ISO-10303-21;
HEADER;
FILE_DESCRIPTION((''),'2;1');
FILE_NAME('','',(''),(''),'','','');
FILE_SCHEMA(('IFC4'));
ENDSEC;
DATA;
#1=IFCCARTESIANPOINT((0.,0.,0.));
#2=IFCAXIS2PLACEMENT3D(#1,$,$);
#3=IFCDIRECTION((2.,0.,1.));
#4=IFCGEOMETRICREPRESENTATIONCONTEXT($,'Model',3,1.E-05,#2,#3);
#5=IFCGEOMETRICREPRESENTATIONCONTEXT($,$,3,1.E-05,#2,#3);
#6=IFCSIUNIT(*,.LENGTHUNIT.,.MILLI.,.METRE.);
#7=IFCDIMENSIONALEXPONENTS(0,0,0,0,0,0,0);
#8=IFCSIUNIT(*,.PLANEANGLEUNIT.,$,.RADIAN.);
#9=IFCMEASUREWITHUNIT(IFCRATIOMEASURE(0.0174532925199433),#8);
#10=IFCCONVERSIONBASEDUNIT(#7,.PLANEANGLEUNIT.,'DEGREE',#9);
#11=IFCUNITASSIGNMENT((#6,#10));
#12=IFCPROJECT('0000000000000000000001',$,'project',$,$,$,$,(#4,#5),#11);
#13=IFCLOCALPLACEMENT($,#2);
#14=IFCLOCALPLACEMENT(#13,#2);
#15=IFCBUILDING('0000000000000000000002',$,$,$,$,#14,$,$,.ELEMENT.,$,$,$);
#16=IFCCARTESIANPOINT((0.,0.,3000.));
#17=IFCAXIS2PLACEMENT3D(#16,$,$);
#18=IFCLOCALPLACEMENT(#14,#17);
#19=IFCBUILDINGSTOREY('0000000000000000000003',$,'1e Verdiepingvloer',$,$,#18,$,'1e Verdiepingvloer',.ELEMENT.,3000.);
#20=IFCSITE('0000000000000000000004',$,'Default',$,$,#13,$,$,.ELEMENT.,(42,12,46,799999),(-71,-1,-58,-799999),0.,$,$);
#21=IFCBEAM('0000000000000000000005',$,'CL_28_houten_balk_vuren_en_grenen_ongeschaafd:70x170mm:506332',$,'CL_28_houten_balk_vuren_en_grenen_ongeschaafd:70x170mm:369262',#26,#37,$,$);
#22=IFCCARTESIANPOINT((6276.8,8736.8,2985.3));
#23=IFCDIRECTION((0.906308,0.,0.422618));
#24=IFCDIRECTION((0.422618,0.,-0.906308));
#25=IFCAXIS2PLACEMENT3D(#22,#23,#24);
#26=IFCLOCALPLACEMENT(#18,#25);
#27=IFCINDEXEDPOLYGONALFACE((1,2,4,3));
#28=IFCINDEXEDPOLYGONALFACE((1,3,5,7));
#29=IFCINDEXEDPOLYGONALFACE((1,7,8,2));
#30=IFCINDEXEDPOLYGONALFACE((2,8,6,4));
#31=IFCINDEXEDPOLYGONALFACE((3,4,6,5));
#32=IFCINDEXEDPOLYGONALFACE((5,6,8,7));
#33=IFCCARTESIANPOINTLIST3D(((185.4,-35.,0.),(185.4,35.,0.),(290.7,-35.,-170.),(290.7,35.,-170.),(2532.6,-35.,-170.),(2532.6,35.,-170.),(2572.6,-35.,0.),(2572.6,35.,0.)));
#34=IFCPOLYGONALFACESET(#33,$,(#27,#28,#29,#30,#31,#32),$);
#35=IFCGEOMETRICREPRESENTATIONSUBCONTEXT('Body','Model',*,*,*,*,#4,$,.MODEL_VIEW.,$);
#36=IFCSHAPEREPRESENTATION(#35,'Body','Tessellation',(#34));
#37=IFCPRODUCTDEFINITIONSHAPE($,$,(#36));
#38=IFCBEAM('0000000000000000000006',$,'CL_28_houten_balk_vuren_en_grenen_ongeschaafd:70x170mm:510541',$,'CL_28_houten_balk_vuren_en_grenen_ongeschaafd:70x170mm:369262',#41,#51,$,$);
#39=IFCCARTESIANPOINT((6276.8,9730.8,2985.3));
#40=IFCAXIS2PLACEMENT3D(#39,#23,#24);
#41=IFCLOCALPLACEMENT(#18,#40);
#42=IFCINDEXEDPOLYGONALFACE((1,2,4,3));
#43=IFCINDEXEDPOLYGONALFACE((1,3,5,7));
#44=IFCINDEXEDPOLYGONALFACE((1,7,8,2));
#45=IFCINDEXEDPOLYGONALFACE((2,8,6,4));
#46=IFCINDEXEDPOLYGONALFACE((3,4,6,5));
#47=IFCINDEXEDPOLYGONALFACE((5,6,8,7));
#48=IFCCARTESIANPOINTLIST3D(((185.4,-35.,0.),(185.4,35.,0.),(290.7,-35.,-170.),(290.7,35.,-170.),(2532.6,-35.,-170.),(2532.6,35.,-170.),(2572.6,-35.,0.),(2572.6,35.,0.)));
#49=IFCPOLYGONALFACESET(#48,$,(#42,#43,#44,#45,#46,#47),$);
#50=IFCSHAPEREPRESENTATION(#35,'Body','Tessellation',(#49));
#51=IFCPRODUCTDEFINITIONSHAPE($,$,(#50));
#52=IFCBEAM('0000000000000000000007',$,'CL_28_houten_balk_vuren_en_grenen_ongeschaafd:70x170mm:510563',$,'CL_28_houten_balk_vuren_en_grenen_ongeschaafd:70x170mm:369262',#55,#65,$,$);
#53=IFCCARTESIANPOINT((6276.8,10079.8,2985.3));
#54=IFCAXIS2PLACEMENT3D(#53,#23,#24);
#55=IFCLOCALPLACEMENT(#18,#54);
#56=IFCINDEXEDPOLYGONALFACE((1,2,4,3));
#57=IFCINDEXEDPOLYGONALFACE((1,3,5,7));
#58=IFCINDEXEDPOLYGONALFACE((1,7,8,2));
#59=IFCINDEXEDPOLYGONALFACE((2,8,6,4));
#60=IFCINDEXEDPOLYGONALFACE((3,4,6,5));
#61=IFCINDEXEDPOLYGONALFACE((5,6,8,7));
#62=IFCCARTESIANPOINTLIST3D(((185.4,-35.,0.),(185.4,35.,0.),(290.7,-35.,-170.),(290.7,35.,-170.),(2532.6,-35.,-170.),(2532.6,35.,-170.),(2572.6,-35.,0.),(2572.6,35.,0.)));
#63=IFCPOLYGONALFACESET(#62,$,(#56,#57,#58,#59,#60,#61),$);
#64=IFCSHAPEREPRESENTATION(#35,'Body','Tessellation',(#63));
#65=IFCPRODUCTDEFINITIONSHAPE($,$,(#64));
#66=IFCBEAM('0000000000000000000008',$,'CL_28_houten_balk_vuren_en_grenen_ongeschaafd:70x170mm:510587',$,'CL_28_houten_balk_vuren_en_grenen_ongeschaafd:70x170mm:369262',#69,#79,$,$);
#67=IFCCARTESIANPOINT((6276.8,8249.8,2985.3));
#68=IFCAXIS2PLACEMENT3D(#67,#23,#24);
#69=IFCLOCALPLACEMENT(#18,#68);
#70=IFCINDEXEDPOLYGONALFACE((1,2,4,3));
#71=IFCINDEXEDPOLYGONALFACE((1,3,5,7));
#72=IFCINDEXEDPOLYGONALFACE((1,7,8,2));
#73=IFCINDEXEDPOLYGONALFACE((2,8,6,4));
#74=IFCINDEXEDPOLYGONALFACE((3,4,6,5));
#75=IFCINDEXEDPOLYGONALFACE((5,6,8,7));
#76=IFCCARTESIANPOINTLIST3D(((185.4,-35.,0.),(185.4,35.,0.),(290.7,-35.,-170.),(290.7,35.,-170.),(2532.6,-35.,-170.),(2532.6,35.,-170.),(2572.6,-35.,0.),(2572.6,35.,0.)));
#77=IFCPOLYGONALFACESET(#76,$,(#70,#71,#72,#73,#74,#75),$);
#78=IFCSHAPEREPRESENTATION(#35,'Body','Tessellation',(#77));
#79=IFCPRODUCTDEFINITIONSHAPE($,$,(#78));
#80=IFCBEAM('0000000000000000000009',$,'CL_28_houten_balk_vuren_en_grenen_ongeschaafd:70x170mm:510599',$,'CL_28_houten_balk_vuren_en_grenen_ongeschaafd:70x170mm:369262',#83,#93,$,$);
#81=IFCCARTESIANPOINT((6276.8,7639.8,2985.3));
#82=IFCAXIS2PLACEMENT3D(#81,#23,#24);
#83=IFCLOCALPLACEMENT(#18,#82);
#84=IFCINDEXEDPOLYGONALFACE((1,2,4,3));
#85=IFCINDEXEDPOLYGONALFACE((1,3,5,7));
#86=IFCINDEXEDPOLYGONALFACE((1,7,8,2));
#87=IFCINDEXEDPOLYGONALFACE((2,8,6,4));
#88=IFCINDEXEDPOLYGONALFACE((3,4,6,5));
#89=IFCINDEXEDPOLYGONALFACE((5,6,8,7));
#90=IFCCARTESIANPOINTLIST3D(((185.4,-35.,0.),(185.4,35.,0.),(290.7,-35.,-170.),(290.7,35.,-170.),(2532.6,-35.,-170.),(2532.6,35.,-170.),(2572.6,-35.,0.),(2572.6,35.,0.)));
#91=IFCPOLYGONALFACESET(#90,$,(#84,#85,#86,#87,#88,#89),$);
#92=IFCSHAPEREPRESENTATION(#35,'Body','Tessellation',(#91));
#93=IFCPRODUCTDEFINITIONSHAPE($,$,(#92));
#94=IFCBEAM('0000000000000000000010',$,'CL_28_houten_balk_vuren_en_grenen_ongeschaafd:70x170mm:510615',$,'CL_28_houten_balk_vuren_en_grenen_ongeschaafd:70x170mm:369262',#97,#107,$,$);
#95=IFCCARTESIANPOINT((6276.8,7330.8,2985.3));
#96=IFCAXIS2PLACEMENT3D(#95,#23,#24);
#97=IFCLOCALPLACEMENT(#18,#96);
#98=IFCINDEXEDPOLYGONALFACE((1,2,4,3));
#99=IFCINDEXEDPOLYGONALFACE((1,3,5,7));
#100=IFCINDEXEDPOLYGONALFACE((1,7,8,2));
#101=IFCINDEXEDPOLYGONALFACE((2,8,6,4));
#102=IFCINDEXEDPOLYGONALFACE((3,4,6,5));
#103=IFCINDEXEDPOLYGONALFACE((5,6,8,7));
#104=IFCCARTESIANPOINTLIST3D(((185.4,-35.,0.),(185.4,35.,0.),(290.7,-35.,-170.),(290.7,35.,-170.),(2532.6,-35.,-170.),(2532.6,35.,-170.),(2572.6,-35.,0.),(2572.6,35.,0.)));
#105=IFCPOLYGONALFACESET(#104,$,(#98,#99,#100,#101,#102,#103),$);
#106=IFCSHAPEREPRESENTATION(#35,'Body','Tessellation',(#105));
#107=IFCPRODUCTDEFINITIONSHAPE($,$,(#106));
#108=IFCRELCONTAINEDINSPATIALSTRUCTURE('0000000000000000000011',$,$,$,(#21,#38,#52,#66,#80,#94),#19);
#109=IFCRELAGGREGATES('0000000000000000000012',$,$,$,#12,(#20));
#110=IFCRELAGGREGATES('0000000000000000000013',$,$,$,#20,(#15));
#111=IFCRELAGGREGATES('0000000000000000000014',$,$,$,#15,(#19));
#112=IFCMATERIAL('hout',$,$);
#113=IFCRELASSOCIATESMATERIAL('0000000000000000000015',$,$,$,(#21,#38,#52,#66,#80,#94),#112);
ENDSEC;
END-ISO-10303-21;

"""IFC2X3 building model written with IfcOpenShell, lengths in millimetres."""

from ifc_helpers import new_model, entity, si_unit, converted_unit, direction, frame, frame_2d, origin, place, context, subcontext, project, spatial, rectangle, extrude, clip, halfspace, material, element, save


model = new_model("IFC2X3")

# Units and contexts
model_context = context("Model", 3, precision=1e-05, world=origin(), true_north=direction((2.0, 0.0, 1.0)))
context_of_model = context(None, 3, precision=1e-05, world=origin(), true_north=direction((2.0, 0.0, 1.0)))
body_context = subcontext(model_context, "Body", "Model", "MODEL_VIEW")
ifc_project = project(units=[si_unit("LENGTHUNIT", "METRE", prefix="MILLI"), converted_unit("PLANEANGLEUNIT", "DEGREE", entity("IfcRatioMeasure", 0.0174532925199433), si_unit("PLANEANGLEUNIT", "RADIAN"), dimensions=[0, 0, 0, 0, 0, 0, 0])], contexts=[model_context, context_of_model])

# Site, building, storey
site_placement = place(None, origin())
site = spatial("IfcSite", under=ifc_project, at=site_placement, Name="Default", CompositionType="ELEMENT", RefLatitude=(42, 12, 46, 799999), RefLongitude=(-71, -1, -58, -799999), RefElevation=0.0)
building_placement = place(site_placement, origin())
building = spatial("IfcBuilding", under=site, at=building_placement, CompositionType="ELEMENT")
storey_placement = place(building_placement, frame((0.0, 0.0, 3000.0)))
storey = spatial("IfcBuildingStorey", under=building, at=storey_placement, Name="1e Verdiepingvloer", LongName="1e Verdiepingvloer", CompositionType="ELEMENT", Elevation=3000.0)

# Beams
ifc_material_1 = material(Name="hout")
beam_1_placement = place(storey_placement, frame((6276.8, 8736.8, 2985.3), z_axis=(0.906308, 0.0, 0.422618), x_axis=(0.422618, 0.0, -0.906308)))
element("IfcBeam", 1, at=beam_1_placement, inside=storey, material=ifc_material_1, Name="CL_28_houten_balk_vuren_en_grenen_ongeschaafd:70x170mm:506332", ObjectType="CL_28_houten_balk_vuren_en_grenen_ongeschaafd:70x170mm:369262", context=body_context, shape_type="Clipping", body=[
    clip(clip(extrude(rectangle(XDim=170.0, YDim=70.0, at=frame_2d((0.0, 0.0), x_axis=(1.0, 0.0))), frame((185.4, 0.0, -85.0), z_axis=(1.0, 0.0, 0.0), x_axis=(0.0, 0.0, -1.0)), (0.0, 0.0, 1.0), 2387.2), halfspace(frame((290.7, -947.7, -170.0), z_axis=(-0.850088, 0.0, -0.52664), x_axis=(-0.52664, 0.0, 0.850088)), False)), halfspace(frame((2532.6, -947.7, -170.0), z_axis=(0.973348, 0.0, -0.229334), x_axis=(0.229334, 0.0, 0.973348)), False)),
])
beam_2_placement = place(storey_placement, frame((6276.8, 9730.8, 2985.3), z_axis=(0.906308, 0.0, 0.422618), x_axis=(0.422618, 0.0, -0.906308)))
element("IfcBeam", 2, at=beam_2_placement, inside=storey, material=ifc_material_1, Name="CL_28_houten_balk_vuren_en_grenen_ongeschaafd:70x170mm:510541", ObjectType="CL_28_houten_balk_vuren_en_grenen_ongeschaafd:70x170mm:369262", context=body_context, shape_type="Clipping", body=[
    clip(clip(extrude(rectangle(XDim=170.0, YDim=70.0, at=frame_2d((0.0, 0.0), x_axis=(1.0, 0.0))), frame((185.4, 0.0, -85.0), z_axis=(1.0, 0.0, 0.0), x_axis=(0.0, 0.0, -1.0)), (0.0, 0.0, 1.0), 2387.2), halfspace(frame((290.7, -1941.7, -170.0), z_axis=(-0.850088, 0.0, -0.52664), x_axis=(-0.52664, 0.0, 0.850088)), False)), halfspace(frame((2532.6, -1941.7, -170.0), z_axis=(0.973348, 0.0, -0.229334), x_axis=(0.229334, 0.0, 0.973348)), False)),
])
beam_3_placement = place(storey_placement, frame((6276.8, 10079.8, 2985.3), z_axis=(0.906308, 0.0, 0.422618), x_axis=(0.422618, 0.0, -0.906308)))
element("IfcBeam", 3, at=beam_3_placement, inside=storey, material=ifc_material_1, Name="CL_28_houten_balk_vuren_en_grenen_ongeschaafd:70x170mm:510563", ObjectType="CL_28_houten_balk_vuren_en_grenen_ongeschaafd:70x170mm:369262", context=body_context, shape_type="Clipping", body=[
    clip(clip(extrude(rectangle(XDim=170.0, YDim=70.0, at=frame_2d((0.0, 0.0), x_axis=(1.0, 0.0))), frame((185.4, 0.0, -85.0), z_axis=(1.0, 0.0, 0.0), x_axis=(0.0, 0.0, -1.0)), (0.0, 0.0, 1.0), 2387.2), halfspace(frame((290.7, -2290.7, -170.0), z_axis=(-0.850088, 0.0, -0.52664), x_axis=(-0.52664, 0.0, 0.850088)), False)), halfspace(frame((2532.6, -2290.7, -170.0), z_axis=(0.973348, 0.0, -0.229334), x_axis=(0.229334, 0.0, 0.973348)), False)),
])
beam_4_placement = place(storey_placement, frame((6276.8, 8249.8, 2985.3), z_axis=(0.906308, 0.0, 0.422618), x_axis=(0.422618, 0.0, -0.906308)))
element("IfcBeam", 4, at=beam_4_placement, inside=storey, material=ifc_material_1, Name="CL_28_houten_balk_vuren_en_grenen_ongeschaafd:70x170mm:510587", ObjectType="CL_28_houten_balk_vuren_en_grenen_ongeschaafd:70x170mm:369262", context=body_context, shape_type="Clipping", body=[
    clip(clip(extrude(rectangle(XDim=170.0, YDim=70.0, at=frame_2d((0.0, 0.0), x_axis=(1.0, 0.0))), frame((185.4, 0.0, -85.0), z_axis=(1.0, 0.0, 0.0), x_axis=(0.0, 0.0, -1.0)), (0.0, 0.0, 1.0), 2387.2), halfspace(frame((2532.6, -460.7, -170.0), z_axis=(0.973348, 0.0, -0.229334), x_axis=(0.229334, 0.0, 0.973348)), False)), halfspace(frame((290.7, -460.7, -170.0), z_axis=(-0.850088, 0.0, -0.52664), x_axis=(-0.52664, 0.0, 0.850088)), False)),
])
beam_5_placement = place(storey_placement, frame((6276.8, 7639.8, 2985.3), z_axis=(0.906308, 0.0, 0.422618), x_axis=(0.422618, 0.0, -0.906308)))
element("IfcBeam", 5, at=beam_5_placement, inside=storey, material=ifc_material_1, Name="CL_28_houten_balk_vuren_en_grenen_ongeschaafd:70x170mm:510599", ObjectType="CL_28_houten_balk_vuren_en_grenen_ongeschaafd:70x170mm:369262", context=body_context, shape_type="Clipping", body=[
    clip(clip(extrude(rectangle(XDim=170.0, YDim=70.0, at=frame_2d((0.0, 0.0), x_axis=(1.0, 0.0))), frame((185.4, 0.0, -85.0), z_axis=(1.0, 0.0, 0.0), x_axis=(0.0, 0.0, -1.0)), (0.0, 0.0, 1.0), 2387.2), halfspace(frame((2532.6, 149.3, -170.0), z_axis=(0.973348, 0.0, -0.229334), x_axis=(0.229334, 0.0, 0.973348)), False)), halfspace(frame((290.7, 149.3, -170.0), z_axis=(-0.850088, 0.0, -0.52664), x_axis=(-0.52664, 0.0, 0.850088)), False)),
])
beam_6_placement = place(storey_placement, frame((6276.8, 7330.8, 2985.3), z_axis=(0.906308, 0.0, 0.422618), x_axis=(0.422618, 0.0, -0.906308)))
element("IfcBeam", 6, at=beam_6_placement, inside=storey, material=ifc_material_1, Name="CL_28_houten_balk_vuren_en_grenen_ongeschaafd:70x170mm:510615", ObjectType="CL_28_houten_balk_vuren_en_grenen_ongeschaafd:70x170mm:369262", context=body_context, shape_type="Clipping", body=[
    clip(clip(extrude(rectangle(XDim=170.0, YDim=70.0, at=frame_2d((0.0, 0.0), x_axis=(1.0, 0.0))), frame((185.4, 0.0, -85.0), z_axis=(1.0, 0.0, 0.0), x_axis=(0.0, 0.0, -1.0)), (0.0, 0.0, 1.0), 2387.2), halfspace(frame((2532.6, 458.3, -170.0), z_axis=(0.973348, 0.0, -0.229334), x_axis=(0.229334, 0.0, 0.973348)), False)), halfspace(frame((290.7, 458.3, -170.0), z_axis=(-0.850088, 0.0, -0.52664), x_axis=(-0.52664, 0.0, 0.850088)), False)),
])

save(model, "model.ifc")
